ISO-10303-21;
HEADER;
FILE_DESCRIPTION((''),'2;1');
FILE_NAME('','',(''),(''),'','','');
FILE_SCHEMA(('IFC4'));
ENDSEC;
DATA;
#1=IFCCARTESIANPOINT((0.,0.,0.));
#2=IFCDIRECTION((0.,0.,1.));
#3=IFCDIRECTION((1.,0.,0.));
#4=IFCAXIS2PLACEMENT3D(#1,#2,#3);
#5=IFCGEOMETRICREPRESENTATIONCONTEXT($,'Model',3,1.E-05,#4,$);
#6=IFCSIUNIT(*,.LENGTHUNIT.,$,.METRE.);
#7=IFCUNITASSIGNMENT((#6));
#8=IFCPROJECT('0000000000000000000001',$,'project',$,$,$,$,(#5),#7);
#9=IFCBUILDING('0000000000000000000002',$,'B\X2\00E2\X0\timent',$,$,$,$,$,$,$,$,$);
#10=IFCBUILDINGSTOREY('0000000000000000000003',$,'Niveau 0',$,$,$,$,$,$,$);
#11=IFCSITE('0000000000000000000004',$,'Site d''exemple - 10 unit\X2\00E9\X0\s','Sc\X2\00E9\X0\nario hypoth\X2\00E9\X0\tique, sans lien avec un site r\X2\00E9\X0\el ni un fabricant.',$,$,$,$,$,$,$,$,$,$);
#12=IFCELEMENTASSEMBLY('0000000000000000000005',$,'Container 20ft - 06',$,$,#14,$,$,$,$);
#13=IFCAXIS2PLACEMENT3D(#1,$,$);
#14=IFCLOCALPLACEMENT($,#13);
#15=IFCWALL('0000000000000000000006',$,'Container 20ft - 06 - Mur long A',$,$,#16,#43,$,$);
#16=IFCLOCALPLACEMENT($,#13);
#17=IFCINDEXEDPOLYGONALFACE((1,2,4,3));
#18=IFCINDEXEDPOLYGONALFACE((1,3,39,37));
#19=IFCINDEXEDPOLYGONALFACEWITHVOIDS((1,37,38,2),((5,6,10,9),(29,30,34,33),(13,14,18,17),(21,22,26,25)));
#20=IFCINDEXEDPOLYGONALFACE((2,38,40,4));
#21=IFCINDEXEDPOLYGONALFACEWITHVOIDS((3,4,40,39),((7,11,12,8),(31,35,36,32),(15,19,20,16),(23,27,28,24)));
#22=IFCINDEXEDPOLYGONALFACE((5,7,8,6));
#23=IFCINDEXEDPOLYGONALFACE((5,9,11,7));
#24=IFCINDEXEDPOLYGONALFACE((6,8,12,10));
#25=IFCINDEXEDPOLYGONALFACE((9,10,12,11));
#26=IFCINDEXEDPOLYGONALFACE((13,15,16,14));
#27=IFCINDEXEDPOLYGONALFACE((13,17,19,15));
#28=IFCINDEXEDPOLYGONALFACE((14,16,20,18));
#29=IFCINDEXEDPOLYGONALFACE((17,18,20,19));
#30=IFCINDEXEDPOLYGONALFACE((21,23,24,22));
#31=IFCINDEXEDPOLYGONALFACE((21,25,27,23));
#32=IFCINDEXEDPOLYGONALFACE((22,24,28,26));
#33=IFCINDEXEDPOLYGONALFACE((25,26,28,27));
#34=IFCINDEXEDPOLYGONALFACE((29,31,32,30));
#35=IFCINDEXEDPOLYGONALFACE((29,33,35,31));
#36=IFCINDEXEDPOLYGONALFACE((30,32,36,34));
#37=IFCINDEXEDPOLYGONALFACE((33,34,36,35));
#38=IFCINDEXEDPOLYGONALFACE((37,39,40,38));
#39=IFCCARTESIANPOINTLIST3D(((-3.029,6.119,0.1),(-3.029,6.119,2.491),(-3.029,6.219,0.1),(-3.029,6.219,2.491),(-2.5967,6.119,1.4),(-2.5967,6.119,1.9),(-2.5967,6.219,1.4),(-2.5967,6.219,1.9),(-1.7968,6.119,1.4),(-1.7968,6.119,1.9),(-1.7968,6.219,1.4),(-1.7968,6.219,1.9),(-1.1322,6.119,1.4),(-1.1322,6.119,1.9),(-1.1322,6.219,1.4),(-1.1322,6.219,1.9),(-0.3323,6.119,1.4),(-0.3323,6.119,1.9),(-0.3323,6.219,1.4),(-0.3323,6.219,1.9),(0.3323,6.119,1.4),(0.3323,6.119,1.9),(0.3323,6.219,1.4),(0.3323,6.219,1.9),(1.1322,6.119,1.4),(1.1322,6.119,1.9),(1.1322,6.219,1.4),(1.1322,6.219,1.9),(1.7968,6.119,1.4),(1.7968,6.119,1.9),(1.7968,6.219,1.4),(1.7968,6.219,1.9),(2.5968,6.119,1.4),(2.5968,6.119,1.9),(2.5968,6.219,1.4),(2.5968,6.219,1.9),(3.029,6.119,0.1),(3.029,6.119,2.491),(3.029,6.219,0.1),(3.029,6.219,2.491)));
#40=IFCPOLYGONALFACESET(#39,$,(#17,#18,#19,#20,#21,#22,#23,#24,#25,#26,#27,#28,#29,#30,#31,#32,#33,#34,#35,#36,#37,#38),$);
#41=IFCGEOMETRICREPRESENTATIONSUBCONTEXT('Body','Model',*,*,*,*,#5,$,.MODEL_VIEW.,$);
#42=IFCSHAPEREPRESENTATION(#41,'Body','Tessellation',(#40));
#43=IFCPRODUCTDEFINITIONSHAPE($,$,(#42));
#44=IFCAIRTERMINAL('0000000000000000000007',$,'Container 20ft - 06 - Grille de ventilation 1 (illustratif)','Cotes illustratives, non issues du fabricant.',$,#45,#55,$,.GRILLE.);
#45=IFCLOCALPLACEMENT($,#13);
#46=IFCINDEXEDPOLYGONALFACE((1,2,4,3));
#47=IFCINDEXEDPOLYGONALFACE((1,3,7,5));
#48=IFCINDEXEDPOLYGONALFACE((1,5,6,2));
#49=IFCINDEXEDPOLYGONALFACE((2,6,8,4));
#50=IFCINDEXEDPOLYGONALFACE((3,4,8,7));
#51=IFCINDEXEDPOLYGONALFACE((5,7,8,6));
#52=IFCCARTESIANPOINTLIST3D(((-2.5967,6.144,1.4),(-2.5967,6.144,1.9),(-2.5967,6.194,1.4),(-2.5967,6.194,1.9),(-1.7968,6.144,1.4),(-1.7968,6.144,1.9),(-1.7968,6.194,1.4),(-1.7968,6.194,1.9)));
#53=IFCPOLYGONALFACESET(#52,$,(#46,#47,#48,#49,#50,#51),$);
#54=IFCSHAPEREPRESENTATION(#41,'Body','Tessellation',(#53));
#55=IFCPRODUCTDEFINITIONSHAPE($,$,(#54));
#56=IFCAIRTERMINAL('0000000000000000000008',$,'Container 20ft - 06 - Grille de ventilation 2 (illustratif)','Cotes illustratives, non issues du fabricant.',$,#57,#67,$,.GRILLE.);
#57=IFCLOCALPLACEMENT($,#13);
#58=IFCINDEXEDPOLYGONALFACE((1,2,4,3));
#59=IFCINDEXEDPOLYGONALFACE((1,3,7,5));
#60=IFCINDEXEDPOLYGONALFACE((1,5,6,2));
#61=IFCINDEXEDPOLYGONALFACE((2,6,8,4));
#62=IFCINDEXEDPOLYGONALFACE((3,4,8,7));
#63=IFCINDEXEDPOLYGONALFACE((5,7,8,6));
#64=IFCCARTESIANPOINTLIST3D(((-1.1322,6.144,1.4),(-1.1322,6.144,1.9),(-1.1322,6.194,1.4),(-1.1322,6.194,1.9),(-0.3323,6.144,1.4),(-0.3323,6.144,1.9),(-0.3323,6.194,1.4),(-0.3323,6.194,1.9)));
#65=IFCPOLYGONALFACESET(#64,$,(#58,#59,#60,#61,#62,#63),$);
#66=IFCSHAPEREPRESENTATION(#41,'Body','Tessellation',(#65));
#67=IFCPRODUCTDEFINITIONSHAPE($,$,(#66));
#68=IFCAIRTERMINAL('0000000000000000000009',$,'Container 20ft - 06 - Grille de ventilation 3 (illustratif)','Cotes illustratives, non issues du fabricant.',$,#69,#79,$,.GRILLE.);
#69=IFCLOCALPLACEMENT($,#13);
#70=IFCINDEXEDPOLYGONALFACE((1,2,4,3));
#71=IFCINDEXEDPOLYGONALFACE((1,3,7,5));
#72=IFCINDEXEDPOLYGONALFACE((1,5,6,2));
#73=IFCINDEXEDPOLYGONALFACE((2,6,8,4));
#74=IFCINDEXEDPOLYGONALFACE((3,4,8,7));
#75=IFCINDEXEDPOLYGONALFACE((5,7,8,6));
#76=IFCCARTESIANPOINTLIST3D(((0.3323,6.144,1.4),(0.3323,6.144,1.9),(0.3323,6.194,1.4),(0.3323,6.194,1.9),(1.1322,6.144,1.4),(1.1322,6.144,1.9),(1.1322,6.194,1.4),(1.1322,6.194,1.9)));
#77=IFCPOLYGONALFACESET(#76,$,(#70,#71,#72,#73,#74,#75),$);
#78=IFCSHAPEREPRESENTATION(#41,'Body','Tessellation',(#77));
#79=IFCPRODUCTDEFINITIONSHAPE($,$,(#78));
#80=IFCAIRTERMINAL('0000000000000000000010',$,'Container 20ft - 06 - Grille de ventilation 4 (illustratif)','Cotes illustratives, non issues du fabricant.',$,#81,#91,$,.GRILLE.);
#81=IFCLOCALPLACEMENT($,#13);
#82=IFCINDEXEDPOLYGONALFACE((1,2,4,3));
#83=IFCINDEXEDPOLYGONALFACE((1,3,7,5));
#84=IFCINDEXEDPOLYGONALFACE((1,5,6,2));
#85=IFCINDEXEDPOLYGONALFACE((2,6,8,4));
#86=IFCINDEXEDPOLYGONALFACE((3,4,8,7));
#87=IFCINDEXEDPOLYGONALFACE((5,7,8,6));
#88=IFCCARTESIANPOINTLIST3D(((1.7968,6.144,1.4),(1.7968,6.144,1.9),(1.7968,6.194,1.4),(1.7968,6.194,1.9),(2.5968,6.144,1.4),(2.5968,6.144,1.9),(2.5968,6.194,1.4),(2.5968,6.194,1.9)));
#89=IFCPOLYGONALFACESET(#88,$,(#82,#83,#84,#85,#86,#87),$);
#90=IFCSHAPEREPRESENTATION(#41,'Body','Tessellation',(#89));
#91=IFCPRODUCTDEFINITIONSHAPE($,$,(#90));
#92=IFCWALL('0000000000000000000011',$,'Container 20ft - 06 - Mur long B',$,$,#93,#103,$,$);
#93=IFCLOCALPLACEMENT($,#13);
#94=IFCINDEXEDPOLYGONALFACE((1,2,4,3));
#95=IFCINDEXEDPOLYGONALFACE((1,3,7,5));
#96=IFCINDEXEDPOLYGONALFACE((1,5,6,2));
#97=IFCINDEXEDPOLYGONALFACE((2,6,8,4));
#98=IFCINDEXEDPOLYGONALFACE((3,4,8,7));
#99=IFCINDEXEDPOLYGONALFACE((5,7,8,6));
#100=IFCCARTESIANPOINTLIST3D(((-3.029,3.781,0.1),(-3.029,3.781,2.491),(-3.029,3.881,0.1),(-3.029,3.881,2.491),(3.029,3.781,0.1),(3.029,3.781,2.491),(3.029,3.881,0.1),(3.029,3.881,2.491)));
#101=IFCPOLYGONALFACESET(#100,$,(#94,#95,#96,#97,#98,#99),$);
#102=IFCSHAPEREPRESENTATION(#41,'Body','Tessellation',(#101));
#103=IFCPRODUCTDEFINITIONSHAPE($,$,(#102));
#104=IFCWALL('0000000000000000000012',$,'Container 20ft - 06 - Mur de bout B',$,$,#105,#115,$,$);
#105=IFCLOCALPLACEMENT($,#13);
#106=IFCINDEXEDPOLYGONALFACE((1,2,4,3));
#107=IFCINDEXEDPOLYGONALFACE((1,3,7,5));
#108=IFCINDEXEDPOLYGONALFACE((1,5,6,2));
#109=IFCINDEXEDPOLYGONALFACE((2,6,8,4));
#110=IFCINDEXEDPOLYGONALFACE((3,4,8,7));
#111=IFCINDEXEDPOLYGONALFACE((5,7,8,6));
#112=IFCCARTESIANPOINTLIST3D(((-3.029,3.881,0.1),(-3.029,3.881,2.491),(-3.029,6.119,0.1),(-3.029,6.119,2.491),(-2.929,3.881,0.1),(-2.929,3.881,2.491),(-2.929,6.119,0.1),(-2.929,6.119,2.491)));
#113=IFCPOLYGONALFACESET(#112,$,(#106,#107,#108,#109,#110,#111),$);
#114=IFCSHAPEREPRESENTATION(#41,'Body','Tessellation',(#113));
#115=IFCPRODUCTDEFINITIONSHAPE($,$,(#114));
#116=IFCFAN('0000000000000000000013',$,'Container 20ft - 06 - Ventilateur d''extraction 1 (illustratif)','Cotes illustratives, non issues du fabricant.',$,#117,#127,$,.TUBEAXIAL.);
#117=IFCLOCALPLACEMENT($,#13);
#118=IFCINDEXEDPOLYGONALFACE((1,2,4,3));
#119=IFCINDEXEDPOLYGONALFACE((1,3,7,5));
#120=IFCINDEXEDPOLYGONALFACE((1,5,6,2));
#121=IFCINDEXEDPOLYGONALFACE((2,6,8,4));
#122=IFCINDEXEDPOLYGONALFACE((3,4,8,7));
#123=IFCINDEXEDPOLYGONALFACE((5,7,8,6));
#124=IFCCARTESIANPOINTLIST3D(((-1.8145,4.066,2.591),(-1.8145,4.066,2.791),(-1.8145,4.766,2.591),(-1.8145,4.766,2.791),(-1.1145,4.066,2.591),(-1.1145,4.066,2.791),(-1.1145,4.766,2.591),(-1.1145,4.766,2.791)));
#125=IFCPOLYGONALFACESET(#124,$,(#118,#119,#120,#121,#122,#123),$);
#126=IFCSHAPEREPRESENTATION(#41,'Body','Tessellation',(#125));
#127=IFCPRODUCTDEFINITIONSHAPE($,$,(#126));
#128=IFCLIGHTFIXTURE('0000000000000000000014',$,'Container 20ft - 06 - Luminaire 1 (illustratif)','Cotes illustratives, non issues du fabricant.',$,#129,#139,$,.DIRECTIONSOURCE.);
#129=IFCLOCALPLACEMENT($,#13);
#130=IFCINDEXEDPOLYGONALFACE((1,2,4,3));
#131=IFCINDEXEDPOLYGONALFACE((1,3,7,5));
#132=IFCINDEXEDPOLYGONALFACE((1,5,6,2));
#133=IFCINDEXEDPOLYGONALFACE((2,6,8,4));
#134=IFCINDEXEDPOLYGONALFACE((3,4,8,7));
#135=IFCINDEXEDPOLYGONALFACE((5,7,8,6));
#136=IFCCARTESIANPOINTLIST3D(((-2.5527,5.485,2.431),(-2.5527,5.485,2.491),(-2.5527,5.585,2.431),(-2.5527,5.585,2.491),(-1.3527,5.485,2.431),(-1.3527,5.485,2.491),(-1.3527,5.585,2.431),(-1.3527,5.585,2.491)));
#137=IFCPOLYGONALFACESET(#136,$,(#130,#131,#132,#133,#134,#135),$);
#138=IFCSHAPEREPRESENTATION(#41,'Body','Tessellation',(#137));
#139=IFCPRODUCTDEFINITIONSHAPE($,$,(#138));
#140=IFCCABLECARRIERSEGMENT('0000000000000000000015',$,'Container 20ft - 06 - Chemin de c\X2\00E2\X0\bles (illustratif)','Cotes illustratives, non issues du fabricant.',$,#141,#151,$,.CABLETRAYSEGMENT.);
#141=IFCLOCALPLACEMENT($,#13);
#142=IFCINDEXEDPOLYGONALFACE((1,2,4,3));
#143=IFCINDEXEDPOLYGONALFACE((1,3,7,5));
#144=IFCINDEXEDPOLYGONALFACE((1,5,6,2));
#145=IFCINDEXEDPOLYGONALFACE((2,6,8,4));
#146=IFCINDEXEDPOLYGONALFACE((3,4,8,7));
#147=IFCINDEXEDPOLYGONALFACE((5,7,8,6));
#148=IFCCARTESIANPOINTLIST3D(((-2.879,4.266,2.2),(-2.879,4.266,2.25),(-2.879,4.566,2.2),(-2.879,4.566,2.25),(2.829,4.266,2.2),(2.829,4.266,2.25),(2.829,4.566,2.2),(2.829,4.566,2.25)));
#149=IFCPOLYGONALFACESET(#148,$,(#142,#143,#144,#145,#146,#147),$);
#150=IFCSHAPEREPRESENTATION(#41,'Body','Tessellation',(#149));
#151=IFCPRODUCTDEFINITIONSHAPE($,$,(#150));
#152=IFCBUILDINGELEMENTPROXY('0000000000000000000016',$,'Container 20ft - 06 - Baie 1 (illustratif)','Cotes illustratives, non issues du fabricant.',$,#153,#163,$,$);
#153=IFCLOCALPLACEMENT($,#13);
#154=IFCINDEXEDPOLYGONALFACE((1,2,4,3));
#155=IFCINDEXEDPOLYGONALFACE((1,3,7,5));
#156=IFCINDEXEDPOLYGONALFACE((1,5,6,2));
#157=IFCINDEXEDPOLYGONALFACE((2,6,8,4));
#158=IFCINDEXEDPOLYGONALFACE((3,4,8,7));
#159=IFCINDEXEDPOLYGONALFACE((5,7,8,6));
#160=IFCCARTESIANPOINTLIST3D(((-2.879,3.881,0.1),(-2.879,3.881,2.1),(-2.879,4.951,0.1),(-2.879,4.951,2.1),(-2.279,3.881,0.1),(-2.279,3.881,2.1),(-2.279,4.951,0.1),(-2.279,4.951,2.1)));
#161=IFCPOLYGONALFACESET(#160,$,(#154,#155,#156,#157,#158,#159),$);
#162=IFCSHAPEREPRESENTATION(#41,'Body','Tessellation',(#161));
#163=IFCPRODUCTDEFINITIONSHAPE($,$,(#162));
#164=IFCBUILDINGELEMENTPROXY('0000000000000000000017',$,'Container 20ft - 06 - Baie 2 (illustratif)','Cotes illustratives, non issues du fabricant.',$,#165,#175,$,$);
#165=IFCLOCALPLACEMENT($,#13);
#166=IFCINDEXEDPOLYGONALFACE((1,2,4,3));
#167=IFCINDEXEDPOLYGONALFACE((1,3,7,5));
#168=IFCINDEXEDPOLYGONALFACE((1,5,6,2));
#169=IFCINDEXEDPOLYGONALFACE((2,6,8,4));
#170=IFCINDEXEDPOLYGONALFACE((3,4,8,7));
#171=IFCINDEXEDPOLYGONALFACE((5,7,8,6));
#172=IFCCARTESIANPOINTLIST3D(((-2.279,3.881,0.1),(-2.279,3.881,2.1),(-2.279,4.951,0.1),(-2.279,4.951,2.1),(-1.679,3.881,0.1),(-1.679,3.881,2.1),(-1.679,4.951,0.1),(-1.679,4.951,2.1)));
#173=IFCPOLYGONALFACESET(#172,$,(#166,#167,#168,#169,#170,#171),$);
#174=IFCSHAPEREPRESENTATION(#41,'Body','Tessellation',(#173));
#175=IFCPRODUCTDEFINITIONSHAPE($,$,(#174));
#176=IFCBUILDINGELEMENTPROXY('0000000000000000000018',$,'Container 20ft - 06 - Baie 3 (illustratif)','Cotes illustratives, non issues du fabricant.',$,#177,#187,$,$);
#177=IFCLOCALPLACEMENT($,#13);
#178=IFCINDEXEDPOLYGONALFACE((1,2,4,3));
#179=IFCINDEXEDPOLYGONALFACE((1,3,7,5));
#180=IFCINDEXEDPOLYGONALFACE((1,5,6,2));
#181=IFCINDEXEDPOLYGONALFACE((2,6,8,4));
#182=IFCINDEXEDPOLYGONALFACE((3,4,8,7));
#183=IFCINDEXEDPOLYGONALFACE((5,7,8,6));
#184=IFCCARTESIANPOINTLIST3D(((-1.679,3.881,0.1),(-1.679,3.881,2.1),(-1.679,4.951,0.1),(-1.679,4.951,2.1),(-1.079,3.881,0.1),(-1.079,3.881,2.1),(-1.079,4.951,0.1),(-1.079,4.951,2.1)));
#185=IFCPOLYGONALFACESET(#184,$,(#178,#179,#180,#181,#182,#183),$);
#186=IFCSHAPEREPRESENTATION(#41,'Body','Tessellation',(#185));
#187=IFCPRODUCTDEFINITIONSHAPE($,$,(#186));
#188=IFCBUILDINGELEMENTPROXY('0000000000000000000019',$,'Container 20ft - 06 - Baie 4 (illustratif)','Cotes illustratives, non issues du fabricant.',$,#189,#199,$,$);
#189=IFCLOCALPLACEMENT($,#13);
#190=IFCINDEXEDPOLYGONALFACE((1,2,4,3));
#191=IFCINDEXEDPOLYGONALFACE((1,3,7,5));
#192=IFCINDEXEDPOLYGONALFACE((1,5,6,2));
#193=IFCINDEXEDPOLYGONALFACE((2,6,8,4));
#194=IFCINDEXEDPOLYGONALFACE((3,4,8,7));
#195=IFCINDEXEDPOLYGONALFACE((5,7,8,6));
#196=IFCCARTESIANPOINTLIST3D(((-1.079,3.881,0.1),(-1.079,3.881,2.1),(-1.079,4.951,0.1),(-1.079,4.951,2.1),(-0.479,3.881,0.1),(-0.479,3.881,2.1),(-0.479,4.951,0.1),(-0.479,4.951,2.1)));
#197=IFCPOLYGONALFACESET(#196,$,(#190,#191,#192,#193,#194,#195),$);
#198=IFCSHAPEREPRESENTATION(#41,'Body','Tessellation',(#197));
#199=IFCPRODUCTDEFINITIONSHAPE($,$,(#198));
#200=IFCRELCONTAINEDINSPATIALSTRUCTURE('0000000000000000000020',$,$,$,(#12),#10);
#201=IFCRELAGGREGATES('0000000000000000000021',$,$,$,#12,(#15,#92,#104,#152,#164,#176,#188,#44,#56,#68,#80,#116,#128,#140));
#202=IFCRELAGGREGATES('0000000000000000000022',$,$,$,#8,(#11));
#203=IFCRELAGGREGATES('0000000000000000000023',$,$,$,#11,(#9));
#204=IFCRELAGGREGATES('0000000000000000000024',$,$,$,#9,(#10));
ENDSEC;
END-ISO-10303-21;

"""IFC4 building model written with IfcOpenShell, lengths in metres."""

from ifc_helpers import new_model, si_unit, frame, origin_with_axes, place, context, subcontext, project, spatial, rectangle, extrude, element, fill, aggregate, save


model = new_model("IFC4")

# Units and contexts
model_context = context("Model", 3, precision=1e-05, world=origin_with_axes())
body_context = subcontext(model_context, "Body", "Model", "MODEL_VIEW")
ifc_project = project(units=[si_unit("LENGTHUNIT", "METRE")], contexts=[model_context])

# Site, building, storey
site = spatial("IfcSite", under=ifc_project, Name="Site d'exemple - 10 unités", Description="Scénario hypothétique, sans lien avec un site réel ni un fabricant.")
building = spatial("IfcBuilding", under=site, Name="Bâtiment")
storey = spatial("IfcBuildingStorey", under=building, Name="Niveau 0")

# Element assembly
assembly_1 = element("IfcElementAssembly", 1, inside=storey, Name="Container 20ft - 06")

# Wall, openings, air terminals
wall_1_placement = place(None, frame((0.0, 6.169, 0.1), z_axis=(0.0, 0.0, 1.0), x_axis=(1.0, 0.0, 0.0)))
wall_1 = element("IfcWall", 2, at=wall_1_placement, Name="Container 20ft - 06 - Mur long A", context=body_context, shape_type="SweptSolid", body=[
    extrude(rectangle(XDim=6.058, YDim=0.1), origin_with_axes(), (0.0, 0.0, 1.0), 2.391),
])
opening_1_placement = place(None, frame((-2.1967, 6.169, 1.4), z_axis=(0.0, 0.0, 1.0), x_axis=(1.0, 0.0, 0.0)))
opening_1 = element("IfcOpeningElement", 3, at=opening_1_placement, cuts=wall_1, PredefinedType="OPENING", context=body_context, shape_type="SweptSolid", body=[
    extrude(rectangle(XDim=0.8, YDim=0.2), origin_with_axes(), (0.0, 0.0, 1.0), 0.5),
])
opening_2_placement = place(None, frame((-0.7323, 6.169, 1.4), z_axis=(0.0, 0.0, 1.0), x_axis=(1.0, 0.0, 0.0)))
opening_2 = element("IfcOpeningElement", 4, at=opening_2_placement, cuts=wall_1, PredefinedType="OPENING", context=body_context, shape_type="SweptSolid", body=[
    extrude(rectangle(XDim=0.8, YDim=0.2), origin_with_axes(), (0.0, 0.0, 1.0), 0.5),
])
opening_3_placement = place(None, frame((0.7323, 6.169, 1.4), z_axis=(0.0, 0.0, 1.0), x_axis=(1.0, 0.0, 0.0)))
opening_3 = element("IfcOpeningElement", 5, at=opening_3_placement, cuts=wall_1, PredefinedType="OPENING", context=body_context, shape_type="SweptSolid", body=[
    extrude(rectangle(XDim=0.8, YDim=0.2), origin_with_axes(), (0.0, 0.0, 1.0), 0.5),
])
opening_4_placement = place(None, frame((2.1968, 6.169, 1.4), z_axis=(0.0, 0.0, 1.0), x_axis=(1.0, 0.0, 0.0)))
opening_4 = element("IfcOpeningElement", 6, at=opening_4_placement, cuts=wall_1, PredefinedType="OPENING", context=body_context, shape_type="SweptSolid", body=[
    extrude(rectangle(XDim=0.8, YDim=0.2), origin_with_axes(), (0.0, 0.0, 1.0), 0.5),
])
air_terminal_1_placement = place(None, frame((-2.1967, 6.169, 1.4), z_axis=(0.0, 0.0, 1.0), x_axis=(1.0, 0.0, 0.0)))
air_terminal_1 = element("IfcAirTerminal", 7, at=air_terminal_1_placement, Name="Container 20ft - 06 - Grille de ventilation 1 (illustratif)", Description="Cotes illustratives, non issues du fabricant.", PredefinedType="GRILLE", context=body_context, shape_type="SweptSolid", body=[
    extrude(rectangle(XDim=0.8, YDim=0.05), origin_with_axes(), (0.0, 0.0, 1.0), 0.5),
])
fill(opening_1, air_terminal_1)
air_terminal_2_placement = place(None, frame((-0.7323, 6.169, 1.4), z_axis=(0.0, 0.0, 1.0), x_axis=(1.0, 0.0, 0.0)))
air_terminal_2 = element("IfcAirTerminal", 8, at=air_terminal_2_placement, Name="Container 20ft - 06 - Grille de ventilation 2 (illustratif)", Description="Cotes illustratives, non issues du fabricant.", PredefinedType="GRILLE", context=body_context, shape_type="SweptSolid", body=[
    extrude(rectangle(XDim=0.8, YDim=0.05), origin_with_axes(), (0.0, 0.0, 1.0), 0.5),
])
fill(opening_2, air_terminal_2)
air_terminal_3_placement = place(None, frame((0.7323, 6.169, 1.4), z_axis=(0.0, 0.0, 1.0), x_axis=(1.0, 0.0, 0.0)))
air_terminal_3 = element("IfcAirTerminal", 9, at=air_terminal_3_placement, Name="Container 20ft - 06 - Grille de ventilation 3 (illustratif)", Description="Cotes illustratives, non issues du fabricant.", PredefinedType="GRILLE", context=body_context, shape_type="SweptSolid", body=[
    extrude(rectangle(XDim=0.8, YDim=0.05), origin_with_axes(), (0.0, 0.0, 1.0), 0.5),
])
fill(opening_3, air_terminal_3)
air_terminal_4_placement = place(None, frame((2.1968, 6.169, 1.4), z_axis=(0.0, 0.0, 1.0), x_axis=(1.0, 0.0, 0.0)))
air_terminal_4 = element("IfcAirTerminal", 10, at=air_terminal_4_placement, Name="Container 20ft - 06 - Grille de ventilation 4 (illustratif)", Description="Cotes illustratives, non issues du fabricant.", PredefinedType="GRILLE", context=body_context, shape_type="SweptSolid", body=[
    extrude(rectangle(XDim=0.8, YDim=0.05), origin_with_axes(), (0.0, 0.0, 1.0), 0.5),
])
fill(opening_4, air_terminal_4)

# Walls
wall_2_placement = place(None, frame((0.0, 3.831, 0.1), z_axis=(0.0, 0.0, 1.0), x_axis=(1.0, 0.0, 0.0)))
wall_2 = element("IfcWall", 11, at=wall_2_placement, Name="Container 20ft - 06 - Mur long B", context=body_context, shape_type="SweptSolid", body=[
    extrude(rectangle(XDim=6.058, YDim=0.1), origin_with_axes(), (0.0, 0.0, 1.0), 2.391),
])
wall_3_placement = place(None, frame((-2.979, 5.0, 0.1), z_axis=(0.0, 0.0, 1.0), x_axis=(1.0, 0.0, 0.0)))
wall_3 = element("IfcWall", 12, at=wall_3_placement, Name="Container 20ft - 06 - Mur de bout B", context=body_context, shape_type="SweptSolid", body=[
    extrude(rectangle(XDim=0.1, YDim=2.238), origin_with_axes(), (0.0, 0.0, 1.0), 2.391),
])

# Fan
fan_placement = place(None, frame((-1.4645, 4.416, 2.591), z_axis=(0.0, 0.0, 1.0), x_axis=(1.0, 0.0, 0.0)))
fan = element("IfcFan", 13, at=fan_placement, Name="Container 20ft - 06 - Ventilateur d'extraction 1 (illustratif)", Description="Cotes illustratives, non issues du fabricant.", PredefinedType="TUBEAXIAL", context=body_context, shape_type="SweptSolid", body=[
    extrude(rectangle(XDim=0.7, YDim=0.7), origin_with_axes(), (0.0, 0.0, 1.0), 0.2),
])

# Light fixture
light_fixture_placement = place(None, frame((-1.9527, 5.535, 2.431), z_axis=(0.0, 0.0, 1.0), x_axis=(1.0, 0.0, 0.0)))
light_fixture = element("IfcLightFixture", 14, at=light_fixture_placement, Name="Container 20ft - 06 - Luminaire 1 (illustratif)", Description="Cotes illustratives, non issues du fabricant.", PredefinedType="DIRECTIONSOURCE", context=body_context, shape_type="SweptSolid", body=[
    extrude(rectangle(XDim=1.2, YDim=0.1), origin_with_axes(), (0.0, 0.0, 1.0), 0.06),
])

# Cable carrier segment
cable_carrier_segment_placement = place(None, frame((-0.025, 4.416, 2.2), z_axis=(0.0, 0.0, 1.0), x_axis=(1.0, 0.0, 0.0)))
cable_carrier_segment = element("IfcCableCarrierSegment", 15, at=cable_carrier_segment_placement, Name="Container 20ft - 06 - Chemin de câbles (illustratif)", Description="Cotes illustratives, non issues du fabricant.", PredefinedType="CABLETRAYSEGMENT", context=body_context, shape_type="SweptSolid", body=[
    extrude(rectangle(XDim=5.708, YDim=0.3), origin_with_axes(), (0.0, 0.0, 1.0), 0.05),
])

# Building element proxies
proxy_1_placement = place(None, frame((-2.579, 4.416, 0.1), z_axis=(0.0, 0.0, 1.0), x_axis=(1.0, 0.0, 0.0)))
proxy_1 = element("IfcBuildingElementProxy", 16, at=proxy_1_placement, Name="Container 20ft - 06 - Baie 1 (illustratif)", Description="Cotes illustratives, non issues du fabricant.", context=body_context, shape_type="SweptSolid", body=[
    extrude(rectangle(XDim=0.6, YDim=1.07), origin_with_axes(), (0.0, 0.0, 1.0), 2.0),
])
proxy_2_placement = place(None, frame((-1.979, 4.416, 0.1), z_axis=(0.0, 0.0, 1.0), x_axis=(1.0, 0.0, 0.0)))
proxy_2 = element("IfcBuildingElementProxy", 17, at=proxy_2_placement, Name="Container 20ft - 06 - Baie 2 (illustratif)", Description="Cotes illustratives, non issues du fabricant.", context=body_context, shape_type="SweptSolid", body=[
    extrude(rectangle(XDim=0.6, YDim=1.07), origin_with_axes(), (0.0, 0.0, 1.0), 2.0),
])
proxy_3_placement = place(None, frame((-1.379, 4.416, 0.1), z_axis=(0.0, 0.0, 1.0), x_axis=(1.0, 0.0, 0.0)))
proxy_3 = element("IfcBuildingElementProxy", 18, at=proxy_3_placement, Name="Container 20ft - 06 - Baie 3 (illustratif)", Description="Cotes illustratives, non issues du fabricant.", context=body_context, shape_type="SweptSolid", body=[
    extrude(rectangle(XDim=0.6, YDim=1.07), origin_with_axes(), (0.0, 0.0, 1.0), 2.0),
])
proxy_4_placement = place(None, frame((-0.779, 4.416, 0.1), z_axis=(0.0, 0.0, 1.0), x_axis=(1.0, 0.0, 0.0)))
proxy_4 = element("IfcBuildingElementProxy", 19, at=proxy_4_placement, Name="Container 20ft - 06 - Baie 4 (illustratif)", Description="Cotes illustratives, non issues du fabricant.", context=body_context, shape_type="SweptSolid", body=[
    extrude(rectangle(XDim=0.6, YDim=1.07), origin_with_axes(), (0.0, 0.0, 1.0), 2.0),
])
aggregate(assembly_1, [wall_1, wall_2, wall_3, proxy_1, proxy_2, proxy_3, proxy_4, air_terminal_1, air_terminal_2, air_terminal_3, air_terminal_4, fan, light_fixture, cable_carrier_segment])

save(model, "model.ifc")
